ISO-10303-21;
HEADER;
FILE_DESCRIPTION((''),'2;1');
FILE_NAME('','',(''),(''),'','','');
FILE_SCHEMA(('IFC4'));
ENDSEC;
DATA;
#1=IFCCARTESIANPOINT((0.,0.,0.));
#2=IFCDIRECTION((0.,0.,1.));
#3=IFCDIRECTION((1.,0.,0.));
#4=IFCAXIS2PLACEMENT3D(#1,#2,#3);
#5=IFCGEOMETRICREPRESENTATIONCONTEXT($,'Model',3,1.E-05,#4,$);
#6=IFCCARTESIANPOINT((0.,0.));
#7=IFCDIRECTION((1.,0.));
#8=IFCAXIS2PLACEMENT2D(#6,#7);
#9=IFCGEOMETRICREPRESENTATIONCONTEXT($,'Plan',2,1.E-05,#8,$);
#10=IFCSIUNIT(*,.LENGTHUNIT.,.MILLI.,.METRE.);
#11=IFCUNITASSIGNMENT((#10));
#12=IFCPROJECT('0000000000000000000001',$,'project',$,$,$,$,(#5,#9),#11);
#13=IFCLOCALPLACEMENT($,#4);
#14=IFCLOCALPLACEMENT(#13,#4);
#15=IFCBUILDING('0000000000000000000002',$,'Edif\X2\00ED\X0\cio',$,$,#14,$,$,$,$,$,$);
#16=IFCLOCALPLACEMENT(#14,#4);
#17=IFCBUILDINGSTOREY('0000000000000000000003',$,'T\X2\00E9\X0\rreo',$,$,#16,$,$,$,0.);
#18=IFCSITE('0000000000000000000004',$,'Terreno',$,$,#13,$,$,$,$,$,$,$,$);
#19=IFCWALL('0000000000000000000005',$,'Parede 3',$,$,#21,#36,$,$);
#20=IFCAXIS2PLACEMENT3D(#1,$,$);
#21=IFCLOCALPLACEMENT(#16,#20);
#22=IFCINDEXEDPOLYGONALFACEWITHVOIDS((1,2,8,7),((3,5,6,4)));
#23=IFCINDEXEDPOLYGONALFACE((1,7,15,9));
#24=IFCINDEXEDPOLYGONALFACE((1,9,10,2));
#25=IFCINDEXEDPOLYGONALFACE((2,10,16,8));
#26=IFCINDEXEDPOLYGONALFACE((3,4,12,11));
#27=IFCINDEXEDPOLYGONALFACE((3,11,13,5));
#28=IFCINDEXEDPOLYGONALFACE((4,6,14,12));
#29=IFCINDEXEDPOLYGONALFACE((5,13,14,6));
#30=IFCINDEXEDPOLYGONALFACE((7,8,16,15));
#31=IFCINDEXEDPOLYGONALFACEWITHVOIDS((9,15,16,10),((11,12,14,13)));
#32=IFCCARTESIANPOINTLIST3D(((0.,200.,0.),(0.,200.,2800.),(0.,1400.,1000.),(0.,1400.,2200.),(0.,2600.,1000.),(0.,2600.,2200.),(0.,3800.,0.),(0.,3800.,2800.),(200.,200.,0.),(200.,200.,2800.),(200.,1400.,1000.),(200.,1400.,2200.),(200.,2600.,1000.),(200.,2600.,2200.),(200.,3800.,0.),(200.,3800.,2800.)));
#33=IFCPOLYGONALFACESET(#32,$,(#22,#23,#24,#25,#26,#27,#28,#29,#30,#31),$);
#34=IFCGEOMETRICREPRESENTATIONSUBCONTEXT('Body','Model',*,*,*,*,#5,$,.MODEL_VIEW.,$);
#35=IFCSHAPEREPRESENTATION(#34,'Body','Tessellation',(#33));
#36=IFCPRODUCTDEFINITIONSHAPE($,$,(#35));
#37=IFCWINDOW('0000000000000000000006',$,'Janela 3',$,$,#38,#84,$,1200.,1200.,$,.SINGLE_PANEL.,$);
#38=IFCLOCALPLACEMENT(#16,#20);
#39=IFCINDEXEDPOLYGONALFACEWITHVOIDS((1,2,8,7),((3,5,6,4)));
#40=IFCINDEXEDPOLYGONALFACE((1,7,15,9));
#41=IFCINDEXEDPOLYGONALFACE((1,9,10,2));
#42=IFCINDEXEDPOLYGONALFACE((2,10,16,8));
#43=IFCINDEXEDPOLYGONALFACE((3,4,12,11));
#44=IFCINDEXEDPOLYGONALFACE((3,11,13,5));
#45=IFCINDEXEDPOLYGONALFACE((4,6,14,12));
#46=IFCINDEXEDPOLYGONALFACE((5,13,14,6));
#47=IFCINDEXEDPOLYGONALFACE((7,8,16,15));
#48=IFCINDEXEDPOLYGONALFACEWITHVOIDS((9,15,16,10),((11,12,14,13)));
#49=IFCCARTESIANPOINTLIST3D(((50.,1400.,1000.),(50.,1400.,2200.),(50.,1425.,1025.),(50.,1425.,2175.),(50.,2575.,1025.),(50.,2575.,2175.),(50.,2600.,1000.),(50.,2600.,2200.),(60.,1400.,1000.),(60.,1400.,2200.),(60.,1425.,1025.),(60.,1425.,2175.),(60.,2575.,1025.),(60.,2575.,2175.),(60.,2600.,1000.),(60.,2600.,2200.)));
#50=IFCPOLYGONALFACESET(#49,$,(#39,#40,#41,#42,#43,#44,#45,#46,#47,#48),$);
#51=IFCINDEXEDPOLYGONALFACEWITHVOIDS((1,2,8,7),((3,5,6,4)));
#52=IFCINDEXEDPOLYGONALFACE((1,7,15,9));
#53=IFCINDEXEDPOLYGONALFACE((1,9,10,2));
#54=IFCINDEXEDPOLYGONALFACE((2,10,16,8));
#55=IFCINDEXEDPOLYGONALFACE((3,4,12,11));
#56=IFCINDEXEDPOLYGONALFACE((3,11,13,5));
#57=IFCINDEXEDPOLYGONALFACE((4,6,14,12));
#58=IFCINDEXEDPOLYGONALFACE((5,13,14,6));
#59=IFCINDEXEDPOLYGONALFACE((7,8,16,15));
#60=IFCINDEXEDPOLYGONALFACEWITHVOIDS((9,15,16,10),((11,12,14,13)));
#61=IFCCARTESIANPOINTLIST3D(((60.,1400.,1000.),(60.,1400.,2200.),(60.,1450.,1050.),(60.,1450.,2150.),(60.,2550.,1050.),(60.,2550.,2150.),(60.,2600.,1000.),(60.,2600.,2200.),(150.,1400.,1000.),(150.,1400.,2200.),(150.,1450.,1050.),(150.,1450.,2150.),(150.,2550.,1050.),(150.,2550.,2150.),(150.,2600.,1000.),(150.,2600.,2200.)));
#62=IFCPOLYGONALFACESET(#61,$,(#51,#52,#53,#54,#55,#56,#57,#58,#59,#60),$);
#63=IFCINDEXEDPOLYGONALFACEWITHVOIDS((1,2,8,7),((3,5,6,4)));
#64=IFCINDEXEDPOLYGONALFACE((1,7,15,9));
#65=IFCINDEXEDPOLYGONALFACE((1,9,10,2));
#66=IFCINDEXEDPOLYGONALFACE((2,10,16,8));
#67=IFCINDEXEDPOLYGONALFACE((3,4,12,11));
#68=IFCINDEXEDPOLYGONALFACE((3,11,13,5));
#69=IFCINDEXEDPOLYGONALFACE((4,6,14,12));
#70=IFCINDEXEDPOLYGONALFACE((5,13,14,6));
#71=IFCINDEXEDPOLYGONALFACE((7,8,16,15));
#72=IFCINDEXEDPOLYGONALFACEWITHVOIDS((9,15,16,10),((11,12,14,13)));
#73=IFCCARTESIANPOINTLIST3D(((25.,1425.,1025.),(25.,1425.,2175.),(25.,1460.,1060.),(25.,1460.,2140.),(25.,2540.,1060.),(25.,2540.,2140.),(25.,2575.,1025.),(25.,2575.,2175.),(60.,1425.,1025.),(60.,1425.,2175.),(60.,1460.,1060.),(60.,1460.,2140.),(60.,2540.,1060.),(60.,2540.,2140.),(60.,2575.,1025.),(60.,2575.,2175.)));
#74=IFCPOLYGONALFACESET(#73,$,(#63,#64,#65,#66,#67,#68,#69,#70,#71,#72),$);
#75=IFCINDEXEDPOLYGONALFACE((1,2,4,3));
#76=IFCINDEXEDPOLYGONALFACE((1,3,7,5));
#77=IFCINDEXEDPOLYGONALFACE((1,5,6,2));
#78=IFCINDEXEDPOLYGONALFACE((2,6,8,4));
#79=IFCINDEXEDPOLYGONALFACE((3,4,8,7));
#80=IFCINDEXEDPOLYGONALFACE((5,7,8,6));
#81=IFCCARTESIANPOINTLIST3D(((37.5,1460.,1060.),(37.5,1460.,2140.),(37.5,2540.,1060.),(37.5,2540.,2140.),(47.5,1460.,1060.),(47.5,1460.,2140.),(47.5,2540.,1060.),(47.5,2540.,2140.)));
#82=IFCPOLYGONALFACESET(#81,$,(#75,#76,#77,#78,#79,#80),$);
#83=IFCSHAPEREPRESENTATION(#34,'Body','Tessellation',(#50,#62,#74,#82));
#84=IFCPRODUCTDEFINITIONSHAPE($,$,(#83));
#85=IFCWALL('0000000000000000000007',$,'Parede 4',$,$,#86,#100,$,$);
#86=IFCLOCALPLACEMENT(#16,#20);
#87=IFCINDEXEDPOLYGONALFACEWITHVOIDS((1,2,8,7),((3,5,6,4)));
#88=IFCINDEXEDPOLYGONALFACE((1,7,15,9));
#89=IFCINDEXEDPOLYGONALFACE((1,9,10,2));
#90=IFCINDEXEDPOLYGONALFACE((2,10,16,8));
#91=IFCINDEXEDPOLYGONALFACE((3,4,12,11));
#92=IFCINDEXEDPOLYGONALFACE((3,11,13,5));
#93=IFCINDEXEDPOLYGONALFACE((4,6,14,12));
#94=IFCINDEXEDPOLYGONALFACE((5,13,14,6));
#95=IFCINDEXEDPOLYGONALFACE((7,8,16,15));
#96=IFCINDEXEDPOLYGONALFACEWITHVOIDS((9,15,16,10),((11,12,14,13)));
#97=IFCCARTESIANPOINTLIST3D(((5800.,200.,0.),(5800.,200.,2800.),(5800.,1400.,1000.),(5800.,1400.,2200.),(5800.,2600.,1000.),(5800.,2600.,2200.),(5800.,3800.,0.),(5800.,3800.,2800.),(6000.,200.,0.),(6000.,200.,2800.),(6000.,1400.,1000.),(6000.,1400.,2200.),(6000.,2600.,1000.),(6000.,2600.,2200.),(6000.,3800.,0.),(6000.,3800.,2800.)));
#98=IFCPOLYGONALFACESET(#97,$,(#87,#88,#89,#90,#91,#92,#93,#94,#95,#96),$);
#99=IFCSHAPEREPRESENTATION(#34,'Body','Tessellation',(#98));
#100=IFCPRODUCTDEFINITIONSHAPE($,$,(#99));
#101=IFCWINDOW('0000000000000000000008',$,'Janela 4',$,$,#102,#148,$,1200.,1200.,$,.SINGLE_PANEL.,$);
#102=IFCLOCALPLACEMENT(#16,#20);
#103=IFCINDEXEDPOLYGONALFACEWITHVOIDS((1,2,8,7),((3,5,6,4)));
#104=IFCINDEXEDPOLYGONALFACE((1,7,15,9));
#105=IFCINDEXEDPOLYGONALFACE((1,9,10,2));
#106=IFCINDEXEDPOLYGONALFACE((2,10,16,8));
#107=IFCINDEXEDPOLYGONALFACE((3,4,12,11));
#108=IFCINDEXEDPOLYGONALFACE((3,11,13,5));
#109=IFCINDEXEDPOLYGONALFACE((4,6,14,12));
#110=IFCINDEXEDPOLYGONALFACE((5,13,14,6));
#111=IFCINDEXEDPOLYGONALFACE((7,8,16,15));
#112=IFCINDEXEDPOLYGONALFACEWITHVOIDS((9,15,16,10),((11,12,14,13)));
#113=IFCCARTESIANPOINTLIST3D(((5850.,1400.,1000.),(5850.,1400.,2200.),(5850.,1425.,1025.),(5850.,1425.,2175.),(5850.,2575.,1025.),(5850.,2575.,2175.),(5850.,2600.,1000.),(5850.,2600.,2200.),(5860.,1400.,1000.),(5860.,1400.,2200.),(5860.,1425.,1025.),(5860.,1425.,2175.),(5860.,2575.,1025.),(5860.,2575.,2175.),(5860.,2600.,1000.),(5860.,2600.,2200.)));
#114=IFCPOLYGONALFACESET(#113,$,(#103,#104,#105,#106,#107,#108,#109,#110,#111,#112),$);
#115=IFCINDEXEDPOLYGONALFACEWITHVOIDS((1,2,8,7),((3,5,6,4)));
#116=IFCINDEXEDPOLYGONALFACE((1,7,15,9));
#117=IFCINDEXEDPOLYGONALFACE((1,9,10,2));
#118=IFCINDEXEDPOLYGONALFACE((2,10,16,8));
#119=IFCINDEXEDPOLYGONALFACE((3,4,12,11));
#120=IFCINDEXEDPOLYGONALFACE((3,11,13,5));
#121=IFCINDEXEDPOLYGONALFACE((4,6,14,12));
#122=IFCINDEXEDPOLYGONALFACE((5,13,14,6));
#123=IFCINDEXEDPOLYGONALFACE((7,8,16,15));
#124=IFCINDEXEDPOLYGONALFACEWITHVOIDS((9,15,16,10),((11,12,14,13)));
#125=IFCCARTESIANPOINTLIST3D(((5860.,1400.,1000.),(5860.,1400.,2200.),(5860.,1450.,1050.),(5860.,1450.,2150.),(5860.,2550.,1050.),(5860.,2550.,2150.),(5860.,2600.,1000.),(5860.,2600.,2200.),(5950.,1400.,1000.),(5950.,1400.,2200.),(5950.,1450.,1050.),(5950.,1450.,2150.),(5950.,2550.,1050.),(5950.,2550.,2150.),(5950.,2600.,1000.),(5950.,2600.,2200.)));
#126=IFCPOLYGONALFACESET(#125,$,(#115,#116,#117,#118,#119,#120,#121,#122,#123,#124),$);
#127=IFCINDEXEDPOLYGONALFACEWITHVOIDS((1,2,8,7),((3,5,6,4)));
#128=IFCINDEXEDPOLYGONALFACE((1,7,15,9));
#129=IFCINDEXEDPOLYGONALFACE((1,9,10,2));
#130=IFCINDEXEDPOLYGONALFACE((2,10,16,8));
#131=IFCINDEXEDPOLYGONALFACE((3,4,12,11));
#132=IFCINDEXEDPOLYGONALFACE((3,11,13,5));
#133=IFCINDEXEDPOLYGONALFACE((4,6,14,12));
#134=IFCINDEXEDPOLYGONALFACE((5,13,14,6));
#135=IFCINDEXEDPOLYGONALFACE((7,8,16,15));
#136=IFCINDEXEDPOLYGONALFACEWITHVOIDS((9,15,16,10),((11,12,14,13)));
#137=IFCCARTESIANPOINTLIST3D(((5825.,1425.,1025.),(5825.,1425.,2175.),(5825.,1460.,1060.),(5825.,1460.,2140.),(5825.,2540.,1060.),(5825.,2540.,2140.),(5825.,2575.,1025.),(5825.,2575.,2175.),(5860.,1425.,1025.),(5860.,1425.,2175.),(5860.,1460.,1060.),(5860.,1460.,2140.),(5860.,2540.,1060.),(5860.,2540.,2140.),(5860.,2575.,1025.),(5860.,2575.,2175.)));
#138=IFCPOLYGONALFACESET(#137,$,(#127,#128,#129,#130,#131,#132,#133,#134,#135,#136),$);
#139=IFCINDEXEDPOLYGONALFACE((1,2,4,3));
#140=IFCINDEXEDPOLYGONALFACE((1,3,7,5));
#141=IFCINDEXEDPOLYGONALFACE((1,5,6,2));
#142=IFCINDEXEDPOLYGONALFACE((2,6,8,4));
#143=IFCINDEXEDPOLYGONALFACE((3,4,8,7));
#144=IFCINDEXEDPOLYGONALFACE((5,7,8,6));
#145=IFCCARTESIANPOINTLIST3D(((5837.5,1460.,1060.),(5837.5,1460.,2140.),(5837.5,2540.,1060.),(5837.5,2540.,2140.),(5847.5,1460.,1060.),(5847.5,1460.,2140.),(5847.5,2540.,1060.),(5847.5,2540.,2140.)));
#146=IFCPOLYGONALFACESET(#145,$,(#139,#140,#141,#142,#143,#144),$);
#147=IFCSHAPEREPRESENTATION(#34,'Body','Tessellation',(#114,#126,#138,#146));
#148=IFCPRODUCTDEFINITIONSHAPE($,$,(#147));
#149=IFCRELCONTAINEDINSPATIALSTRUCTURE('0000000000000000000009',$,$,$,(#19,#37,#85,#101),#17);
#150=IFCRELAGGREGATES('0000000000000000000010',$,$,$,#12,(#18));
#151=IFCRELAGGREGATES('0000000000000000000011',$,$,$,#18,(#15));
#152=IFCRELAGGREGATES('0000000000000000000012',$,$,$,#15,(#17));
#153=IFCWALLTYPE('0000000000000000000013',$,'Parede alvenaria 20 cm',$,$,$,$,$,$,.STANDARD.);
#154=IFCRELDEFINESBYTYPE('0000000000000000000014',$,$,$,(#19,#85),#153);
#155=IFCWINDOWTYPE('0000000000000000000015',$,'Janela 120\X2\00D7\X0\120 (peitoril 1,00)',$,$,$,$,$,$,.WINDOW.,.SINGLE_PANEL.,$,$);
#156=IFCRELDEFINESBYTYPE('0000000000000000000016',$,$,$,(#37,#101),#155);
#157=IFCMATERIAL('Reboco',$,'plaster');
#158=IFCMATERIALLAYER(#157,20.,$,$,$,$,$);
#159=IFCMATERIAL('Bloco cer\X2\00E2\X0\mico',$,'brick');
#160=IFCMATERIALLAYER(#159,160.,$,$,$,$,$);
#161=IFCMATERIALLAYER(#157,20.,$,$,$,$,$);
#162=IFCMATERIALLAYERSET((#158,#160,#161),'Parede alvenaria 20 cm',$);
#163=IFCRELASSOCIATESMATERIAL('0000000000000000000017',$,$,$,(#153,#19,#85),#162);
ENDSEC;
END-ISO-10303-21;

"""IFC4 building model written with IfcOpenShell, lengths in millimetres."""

from ifc_helpers import new_model, si_unit, frame, origin_with_axes, origin_2d_with_axis, place, context, subcontext, project, spatial, line, indexed_curve, outline, extrude, material, layer, layer_set, layer_usage, type_object, element, fill, save


model = new_model("IFC4")

# Units and contexts
model_context = context("Model", 3, precision=1e-05, world=origin_with_axes())
plan_context = context("Plan", 2, precision=1e-05, world=origin_2d_with_axis())
body_context_1 = subcontext(model_context, "Body", "Model", "MODEL_VIEW")
ifc_project = project(units=[si_unit("LENGTHUNIT", "METRE", prefix="MILLI")], contexts=[model_context, plan_context])

# Site, building, storey
site_placement = place(None, origin_with_axes())
site = spatial("IfcSite", under=ifc_project, at=site_placement, Name="Terreno")
building_placement = place(site_placement, origin_with_axes())
building = spatial("IfcBuilding", under=site, at=building_placement, Name="Edifício")
storey_placement = place(building_placement, origin_with_axes())
storey = spatial("IfcBuildingStorey", under=building, at=storey_placement, Name="Térreo", Elevation=0.0)

# Shared definitions
ifc_material_1 = material(Name="Reboco", Category="plaster")
ifc_layer_1 = layer(ifc_material_1, 20.0)
ifc_material_2 = material(Name="Bloco cerâmico", Category="brick")
ifc_layer_2 = layer(ifc_material_2, 160.0)
ifc_layer_3 = layer(ifc_material_1, 20.0)
ifc_layer_set_1 = layer_set([ifc_layer_1, ifc_layer_2, ifc_layer_3], Name="Parede alvenaria 20 cm")
wall_type = type_object("IfcWallType", Name="Parede alvenaria 20 cm", PredefinedType="STANDARD", material=ifc_layer_set_1)
window_type = type_object("IfcWindowType", Name="Janela 120×120 (peitoril 1,00)", PartitioningType="SINGLE_PANEL", PredefinedType="WINDOW")

# Walls, openings, windows
ifc_layer_usage_1 = layer_usage(ifc_layer_set_1, "AXIS2", "POSITIVE", -100.0)
wall_1_placement = place(storey_placement, frame((100.0, 200.0, 0.0), z_axis=(0.0, 0.0, 1.0), x_axis=(0.0, 1.0, 0.0)))
wall_1 = element("IfcWall", 1, at=wall_1_placement, inside=storey, type_object=wall_type, material=ifc_layer_usage_1, Name="Parede 3", context=body_context_1, shape_type="SweptSolid", body=[
    extrude(outline(indexed_curve([(0.0, 0.0), (0.0, 200.0), (3600.0, 200.0), (3600.0, 0.0), (0.0, 0.0)], self_intersect=False)), frame((0.0, -100.0, 0.0), z_axis=(0.0, 0.0, 1.0), x_axis=(1.0, 0.0, 0.0)), (0.0, 0.0, 1.0), 2800.0),
])
opening_1_placement = place(wall_1_placement, frame((1200.0, -110.0, 1000.0), z_axis=(0.0, 0.0, 1.0), x_axis=(1.0, 0.0, 0.0)))
opening_1 = element("IfcOpeningElement", 2, at=opening_1_placement, cuts=wall_1, context=body_context_1, shape_type="SweptSolid", body=[
    extrude(outline(indexed_curve([(0.0, 0.0), (0.0, 220.0), (1200.0, 220.0), (1200.0, 0.0), (0.0, 0.0)], self_intersect=False)), origin_with_axes(), (0.0, 0.0, 1.0), 1200.0),
])
window_1_placement = place(opening_1_placement, frame((0.0, 10.0, 0.0), z_axis=(0.0, 0.0, 1.0), x_axis=(1.0, 0.0, 0.0)))
window_1 = element("IfcWindow", 3, at=window_1_placement, inside=storey, type_object=window_type, Name="Janela 3", OverallHeight=1200.0, OverallWidth=1200.0, PartitioningType="SINGLE_PANEL", context=body_context_1, shape_type="SweptSolid", body=[
    extrude(outline(indexed_curve([(0.0, 0.0), (1200.0, 0.0), (1200.0, 1200.0), (0.0, 1200.0)], segments=[line(1, 2, 3, 4, 1)]), holes=[indexed_curve([(25.0, 25.0), (1175.0, 25.0), (1175.0, 1175.0), (25.0, 1175.0)], segments=[line(1, 2, 3, 4, 1)])]), frame((0.0, 140.0, 0.0), z_axis=(0.0, -1.0, 0.0), x_axis=(1.0, 0.0, 0.0)), (0.0, 0.0, -1.0), 10.0),
    extrude(outline(indexed_curve([(0.0, 0.0), (1200.0, 0.0), (1200.0, 1200.0), (0.0, 1200.0)], segments=[line(1, 2, 3, 4, 1)]), holes=[indexed_curve([(50.0, 50.0), (1150.0, 50.0), (1150.0, 1150.0), (50.0, 1150.0)], segments=[line(1, 2, 3, 4, 1)])]), frame((0.0, 50.0, 0.0), z_axis=(0.0, -1.0, 0.0), x_axis=(1.0, 0.0, 0.0)), (0.0, 0.0, -1.0), 90.0),
    extrude(outline(indexed_curve([(0.0, 0.0), (1150.0, 0.0), (1150.0, 1150.0), (0.0, 1150.0)], segments=[line(1, 2, 3, 4, 1)]), holes=[indexed_curve([(35.0, 35.0), (1115.0, 35.0), (1115.0, 1115.0), (35.0, 1115.0)], segments=[line(1, 2, 3, 4, 1)])]), frame((25.0, 140.0, 25.0), z_axis=(0.0, -1.0, 0.0), x_axis=(1.0, 0.0, 0.0)), (0.0, 0.0, -1.0), 35.0),
    extrude(outline(indexed_curve([(35.0, 35.0), (1115.0, 35.0), (1115.0, 1115.0), (35.0, 1115.0)], segments=[line(1, 2, 3, 4, 1)])), frame((25.0, 152.5, 25.0), z_axis=(0.0, -1.0, 0.0), x_axis=(1.0, 0.0, 0.0)), (0.0, 0.0, -1.0), 10.0),
])
fill(opening_1, window_1)
ifc_layer_usage_2 = layer_usage(ifc_layer_set_1, "AXIS2", "POSITIVE", -100.0)
wall_2_placement = place(storey_placement, frame((5900.0, 200.0, 0.0), z_axis=(0.0, 0.0, 1.0), x_axis=(0.0, 1.0, 0.0)))
wall_2 = element("IfcWall", 4, at=wall_2_placement, inside=storey, type_object=wall_type, material=ifc_layer_usage_2, Name="Parede 4", context=body_context_1, shape_type="SweptSolid", body=[
    extrude(outline(indexed_curve([(0.0, 0.0), (0.0, 200.0), (3600.0, 200.0), (3600.0, 0.0), (0.0, 0.0)], self_intersect=False)), frame((0.0, -100.0, 0.0), z_axis=(0.0, 0.0, 1.0), x_axis=(1.0, 0.0, 0.0)), (0.0, 0.0, 1.0), 2800.0),
])
opening_2_placement = place(wall_2_placement, frame((1200.0, -110.0, 1000.0), z_axis=(0.0, 0.0, 1.0), x_axis=(1.0, 0.0, 0.0)))
opening_2 = element("IfcOpeningElement", 5, at=opening_2_placement, cuts=wall_2, context=body_context_1, shape_type="SweptSolid", body=[
    extrude(outline(indexed_curve([(0.0, 0.0), (0.0, 220.0), (1200.0, 220.0), (1200.0, 0.0), (0.0, 0.0)], self_intersect=False)), origin_with_axes(), (0.0, 0.0, 1.0), 1200.0),
])
window_2_placement = place(opening_2_placement, frame((0.0, 10.0, 0.0), z_axis=(0.0, 0.0, 1.0), x_axis=(1.0, 0.0, 0.0)))
window_2 = element("IfcWindow", 6, at=window_2_placement, inside=storey, type_object=window_type, Name="Janela 4", OverallHeight=1200.0, OverallWidth=1200.0, PartitioningType="SINGLE_PANEL", context=body_context_1, shape_type="SweptSolid", body=[
    extrude(outline(indexed_curve([(0.0, 0.0), (1200.0, 0.0), (1200.0, 1200.0), (0.0, 1200.0)], segments=[line(1, 2, 3, 4, 1)]), holes=[indexed_curve([(25.0, 25.0), (1175.0, 25.0), (1175.0, 1175.0), (25.0, 1175.0)], segments=[line(1, 2, 3, 4, 1)])]), frame((0.0, 140.0, 0.0), z_axis=(0.0, -1.0, 0.0), x_axis=(1.0, 0.0, 0.0)), (0.0, 0.0, -1.0), 10.0),
    extrude(outline(indexed_curve([(0.0, 0.0), (1200.0, 0.0), (1200.0, 1200.0), (0.0, 1200.0)], segments=[line(1, 2, 3, 4, 1)]), holes=[indexed_curve([(50.0, 50.0), (1150.0, 50.0), (1150.0, 1150.0), (50.0, 1150.0)], segments=[line(1, 2, 3, 4, 1)])]), frame((0.0, 50.0, 0.0), z_axis=(0.0, -1.0, 0.0), x_axis=(1.0, 0.0, 0.0)), (0.0, 0.0, -1.0), 90.0),
    extrude(outline(indexed_curve([(0.0, 0.0), (1150.0, 0.0), (1150.0, 1150.0), (0.0, 1150.0)], segments=[line(1, 2, 3, 4, 1)]), holes=[indexed_curve([(35.0, 35.0), (1115.0, 35.0), (1115.0, 1115.0), (35.0, 1115.0)], segments=[line(1, 2, 3, 4, 1)])]), frame((25.0, 140.0, 25.0), z_axis=(0.0, -1.0, 0.0), x_axis=(1.0, 0.0, 0.0)), (0.0, 0.0, -1.0), 35.0),
    extrude(outline(indexed_curve([(35.0, 35.0), (1115.0, 35.0), (1115.0, 1115.0), (35.0, 1115.0)], segments=[line(1, 2, 3, 4, 1)])), frame((25.0, 152.5, 25.0), z_axis=(0.0, -1.0, 0.0), x_axis=(1.0, 0.0, 0.0)), (0.0, 0.0, -1.0), 10.0),
])
fill(opening_2, window_2)

save(model, "model.ifc")
